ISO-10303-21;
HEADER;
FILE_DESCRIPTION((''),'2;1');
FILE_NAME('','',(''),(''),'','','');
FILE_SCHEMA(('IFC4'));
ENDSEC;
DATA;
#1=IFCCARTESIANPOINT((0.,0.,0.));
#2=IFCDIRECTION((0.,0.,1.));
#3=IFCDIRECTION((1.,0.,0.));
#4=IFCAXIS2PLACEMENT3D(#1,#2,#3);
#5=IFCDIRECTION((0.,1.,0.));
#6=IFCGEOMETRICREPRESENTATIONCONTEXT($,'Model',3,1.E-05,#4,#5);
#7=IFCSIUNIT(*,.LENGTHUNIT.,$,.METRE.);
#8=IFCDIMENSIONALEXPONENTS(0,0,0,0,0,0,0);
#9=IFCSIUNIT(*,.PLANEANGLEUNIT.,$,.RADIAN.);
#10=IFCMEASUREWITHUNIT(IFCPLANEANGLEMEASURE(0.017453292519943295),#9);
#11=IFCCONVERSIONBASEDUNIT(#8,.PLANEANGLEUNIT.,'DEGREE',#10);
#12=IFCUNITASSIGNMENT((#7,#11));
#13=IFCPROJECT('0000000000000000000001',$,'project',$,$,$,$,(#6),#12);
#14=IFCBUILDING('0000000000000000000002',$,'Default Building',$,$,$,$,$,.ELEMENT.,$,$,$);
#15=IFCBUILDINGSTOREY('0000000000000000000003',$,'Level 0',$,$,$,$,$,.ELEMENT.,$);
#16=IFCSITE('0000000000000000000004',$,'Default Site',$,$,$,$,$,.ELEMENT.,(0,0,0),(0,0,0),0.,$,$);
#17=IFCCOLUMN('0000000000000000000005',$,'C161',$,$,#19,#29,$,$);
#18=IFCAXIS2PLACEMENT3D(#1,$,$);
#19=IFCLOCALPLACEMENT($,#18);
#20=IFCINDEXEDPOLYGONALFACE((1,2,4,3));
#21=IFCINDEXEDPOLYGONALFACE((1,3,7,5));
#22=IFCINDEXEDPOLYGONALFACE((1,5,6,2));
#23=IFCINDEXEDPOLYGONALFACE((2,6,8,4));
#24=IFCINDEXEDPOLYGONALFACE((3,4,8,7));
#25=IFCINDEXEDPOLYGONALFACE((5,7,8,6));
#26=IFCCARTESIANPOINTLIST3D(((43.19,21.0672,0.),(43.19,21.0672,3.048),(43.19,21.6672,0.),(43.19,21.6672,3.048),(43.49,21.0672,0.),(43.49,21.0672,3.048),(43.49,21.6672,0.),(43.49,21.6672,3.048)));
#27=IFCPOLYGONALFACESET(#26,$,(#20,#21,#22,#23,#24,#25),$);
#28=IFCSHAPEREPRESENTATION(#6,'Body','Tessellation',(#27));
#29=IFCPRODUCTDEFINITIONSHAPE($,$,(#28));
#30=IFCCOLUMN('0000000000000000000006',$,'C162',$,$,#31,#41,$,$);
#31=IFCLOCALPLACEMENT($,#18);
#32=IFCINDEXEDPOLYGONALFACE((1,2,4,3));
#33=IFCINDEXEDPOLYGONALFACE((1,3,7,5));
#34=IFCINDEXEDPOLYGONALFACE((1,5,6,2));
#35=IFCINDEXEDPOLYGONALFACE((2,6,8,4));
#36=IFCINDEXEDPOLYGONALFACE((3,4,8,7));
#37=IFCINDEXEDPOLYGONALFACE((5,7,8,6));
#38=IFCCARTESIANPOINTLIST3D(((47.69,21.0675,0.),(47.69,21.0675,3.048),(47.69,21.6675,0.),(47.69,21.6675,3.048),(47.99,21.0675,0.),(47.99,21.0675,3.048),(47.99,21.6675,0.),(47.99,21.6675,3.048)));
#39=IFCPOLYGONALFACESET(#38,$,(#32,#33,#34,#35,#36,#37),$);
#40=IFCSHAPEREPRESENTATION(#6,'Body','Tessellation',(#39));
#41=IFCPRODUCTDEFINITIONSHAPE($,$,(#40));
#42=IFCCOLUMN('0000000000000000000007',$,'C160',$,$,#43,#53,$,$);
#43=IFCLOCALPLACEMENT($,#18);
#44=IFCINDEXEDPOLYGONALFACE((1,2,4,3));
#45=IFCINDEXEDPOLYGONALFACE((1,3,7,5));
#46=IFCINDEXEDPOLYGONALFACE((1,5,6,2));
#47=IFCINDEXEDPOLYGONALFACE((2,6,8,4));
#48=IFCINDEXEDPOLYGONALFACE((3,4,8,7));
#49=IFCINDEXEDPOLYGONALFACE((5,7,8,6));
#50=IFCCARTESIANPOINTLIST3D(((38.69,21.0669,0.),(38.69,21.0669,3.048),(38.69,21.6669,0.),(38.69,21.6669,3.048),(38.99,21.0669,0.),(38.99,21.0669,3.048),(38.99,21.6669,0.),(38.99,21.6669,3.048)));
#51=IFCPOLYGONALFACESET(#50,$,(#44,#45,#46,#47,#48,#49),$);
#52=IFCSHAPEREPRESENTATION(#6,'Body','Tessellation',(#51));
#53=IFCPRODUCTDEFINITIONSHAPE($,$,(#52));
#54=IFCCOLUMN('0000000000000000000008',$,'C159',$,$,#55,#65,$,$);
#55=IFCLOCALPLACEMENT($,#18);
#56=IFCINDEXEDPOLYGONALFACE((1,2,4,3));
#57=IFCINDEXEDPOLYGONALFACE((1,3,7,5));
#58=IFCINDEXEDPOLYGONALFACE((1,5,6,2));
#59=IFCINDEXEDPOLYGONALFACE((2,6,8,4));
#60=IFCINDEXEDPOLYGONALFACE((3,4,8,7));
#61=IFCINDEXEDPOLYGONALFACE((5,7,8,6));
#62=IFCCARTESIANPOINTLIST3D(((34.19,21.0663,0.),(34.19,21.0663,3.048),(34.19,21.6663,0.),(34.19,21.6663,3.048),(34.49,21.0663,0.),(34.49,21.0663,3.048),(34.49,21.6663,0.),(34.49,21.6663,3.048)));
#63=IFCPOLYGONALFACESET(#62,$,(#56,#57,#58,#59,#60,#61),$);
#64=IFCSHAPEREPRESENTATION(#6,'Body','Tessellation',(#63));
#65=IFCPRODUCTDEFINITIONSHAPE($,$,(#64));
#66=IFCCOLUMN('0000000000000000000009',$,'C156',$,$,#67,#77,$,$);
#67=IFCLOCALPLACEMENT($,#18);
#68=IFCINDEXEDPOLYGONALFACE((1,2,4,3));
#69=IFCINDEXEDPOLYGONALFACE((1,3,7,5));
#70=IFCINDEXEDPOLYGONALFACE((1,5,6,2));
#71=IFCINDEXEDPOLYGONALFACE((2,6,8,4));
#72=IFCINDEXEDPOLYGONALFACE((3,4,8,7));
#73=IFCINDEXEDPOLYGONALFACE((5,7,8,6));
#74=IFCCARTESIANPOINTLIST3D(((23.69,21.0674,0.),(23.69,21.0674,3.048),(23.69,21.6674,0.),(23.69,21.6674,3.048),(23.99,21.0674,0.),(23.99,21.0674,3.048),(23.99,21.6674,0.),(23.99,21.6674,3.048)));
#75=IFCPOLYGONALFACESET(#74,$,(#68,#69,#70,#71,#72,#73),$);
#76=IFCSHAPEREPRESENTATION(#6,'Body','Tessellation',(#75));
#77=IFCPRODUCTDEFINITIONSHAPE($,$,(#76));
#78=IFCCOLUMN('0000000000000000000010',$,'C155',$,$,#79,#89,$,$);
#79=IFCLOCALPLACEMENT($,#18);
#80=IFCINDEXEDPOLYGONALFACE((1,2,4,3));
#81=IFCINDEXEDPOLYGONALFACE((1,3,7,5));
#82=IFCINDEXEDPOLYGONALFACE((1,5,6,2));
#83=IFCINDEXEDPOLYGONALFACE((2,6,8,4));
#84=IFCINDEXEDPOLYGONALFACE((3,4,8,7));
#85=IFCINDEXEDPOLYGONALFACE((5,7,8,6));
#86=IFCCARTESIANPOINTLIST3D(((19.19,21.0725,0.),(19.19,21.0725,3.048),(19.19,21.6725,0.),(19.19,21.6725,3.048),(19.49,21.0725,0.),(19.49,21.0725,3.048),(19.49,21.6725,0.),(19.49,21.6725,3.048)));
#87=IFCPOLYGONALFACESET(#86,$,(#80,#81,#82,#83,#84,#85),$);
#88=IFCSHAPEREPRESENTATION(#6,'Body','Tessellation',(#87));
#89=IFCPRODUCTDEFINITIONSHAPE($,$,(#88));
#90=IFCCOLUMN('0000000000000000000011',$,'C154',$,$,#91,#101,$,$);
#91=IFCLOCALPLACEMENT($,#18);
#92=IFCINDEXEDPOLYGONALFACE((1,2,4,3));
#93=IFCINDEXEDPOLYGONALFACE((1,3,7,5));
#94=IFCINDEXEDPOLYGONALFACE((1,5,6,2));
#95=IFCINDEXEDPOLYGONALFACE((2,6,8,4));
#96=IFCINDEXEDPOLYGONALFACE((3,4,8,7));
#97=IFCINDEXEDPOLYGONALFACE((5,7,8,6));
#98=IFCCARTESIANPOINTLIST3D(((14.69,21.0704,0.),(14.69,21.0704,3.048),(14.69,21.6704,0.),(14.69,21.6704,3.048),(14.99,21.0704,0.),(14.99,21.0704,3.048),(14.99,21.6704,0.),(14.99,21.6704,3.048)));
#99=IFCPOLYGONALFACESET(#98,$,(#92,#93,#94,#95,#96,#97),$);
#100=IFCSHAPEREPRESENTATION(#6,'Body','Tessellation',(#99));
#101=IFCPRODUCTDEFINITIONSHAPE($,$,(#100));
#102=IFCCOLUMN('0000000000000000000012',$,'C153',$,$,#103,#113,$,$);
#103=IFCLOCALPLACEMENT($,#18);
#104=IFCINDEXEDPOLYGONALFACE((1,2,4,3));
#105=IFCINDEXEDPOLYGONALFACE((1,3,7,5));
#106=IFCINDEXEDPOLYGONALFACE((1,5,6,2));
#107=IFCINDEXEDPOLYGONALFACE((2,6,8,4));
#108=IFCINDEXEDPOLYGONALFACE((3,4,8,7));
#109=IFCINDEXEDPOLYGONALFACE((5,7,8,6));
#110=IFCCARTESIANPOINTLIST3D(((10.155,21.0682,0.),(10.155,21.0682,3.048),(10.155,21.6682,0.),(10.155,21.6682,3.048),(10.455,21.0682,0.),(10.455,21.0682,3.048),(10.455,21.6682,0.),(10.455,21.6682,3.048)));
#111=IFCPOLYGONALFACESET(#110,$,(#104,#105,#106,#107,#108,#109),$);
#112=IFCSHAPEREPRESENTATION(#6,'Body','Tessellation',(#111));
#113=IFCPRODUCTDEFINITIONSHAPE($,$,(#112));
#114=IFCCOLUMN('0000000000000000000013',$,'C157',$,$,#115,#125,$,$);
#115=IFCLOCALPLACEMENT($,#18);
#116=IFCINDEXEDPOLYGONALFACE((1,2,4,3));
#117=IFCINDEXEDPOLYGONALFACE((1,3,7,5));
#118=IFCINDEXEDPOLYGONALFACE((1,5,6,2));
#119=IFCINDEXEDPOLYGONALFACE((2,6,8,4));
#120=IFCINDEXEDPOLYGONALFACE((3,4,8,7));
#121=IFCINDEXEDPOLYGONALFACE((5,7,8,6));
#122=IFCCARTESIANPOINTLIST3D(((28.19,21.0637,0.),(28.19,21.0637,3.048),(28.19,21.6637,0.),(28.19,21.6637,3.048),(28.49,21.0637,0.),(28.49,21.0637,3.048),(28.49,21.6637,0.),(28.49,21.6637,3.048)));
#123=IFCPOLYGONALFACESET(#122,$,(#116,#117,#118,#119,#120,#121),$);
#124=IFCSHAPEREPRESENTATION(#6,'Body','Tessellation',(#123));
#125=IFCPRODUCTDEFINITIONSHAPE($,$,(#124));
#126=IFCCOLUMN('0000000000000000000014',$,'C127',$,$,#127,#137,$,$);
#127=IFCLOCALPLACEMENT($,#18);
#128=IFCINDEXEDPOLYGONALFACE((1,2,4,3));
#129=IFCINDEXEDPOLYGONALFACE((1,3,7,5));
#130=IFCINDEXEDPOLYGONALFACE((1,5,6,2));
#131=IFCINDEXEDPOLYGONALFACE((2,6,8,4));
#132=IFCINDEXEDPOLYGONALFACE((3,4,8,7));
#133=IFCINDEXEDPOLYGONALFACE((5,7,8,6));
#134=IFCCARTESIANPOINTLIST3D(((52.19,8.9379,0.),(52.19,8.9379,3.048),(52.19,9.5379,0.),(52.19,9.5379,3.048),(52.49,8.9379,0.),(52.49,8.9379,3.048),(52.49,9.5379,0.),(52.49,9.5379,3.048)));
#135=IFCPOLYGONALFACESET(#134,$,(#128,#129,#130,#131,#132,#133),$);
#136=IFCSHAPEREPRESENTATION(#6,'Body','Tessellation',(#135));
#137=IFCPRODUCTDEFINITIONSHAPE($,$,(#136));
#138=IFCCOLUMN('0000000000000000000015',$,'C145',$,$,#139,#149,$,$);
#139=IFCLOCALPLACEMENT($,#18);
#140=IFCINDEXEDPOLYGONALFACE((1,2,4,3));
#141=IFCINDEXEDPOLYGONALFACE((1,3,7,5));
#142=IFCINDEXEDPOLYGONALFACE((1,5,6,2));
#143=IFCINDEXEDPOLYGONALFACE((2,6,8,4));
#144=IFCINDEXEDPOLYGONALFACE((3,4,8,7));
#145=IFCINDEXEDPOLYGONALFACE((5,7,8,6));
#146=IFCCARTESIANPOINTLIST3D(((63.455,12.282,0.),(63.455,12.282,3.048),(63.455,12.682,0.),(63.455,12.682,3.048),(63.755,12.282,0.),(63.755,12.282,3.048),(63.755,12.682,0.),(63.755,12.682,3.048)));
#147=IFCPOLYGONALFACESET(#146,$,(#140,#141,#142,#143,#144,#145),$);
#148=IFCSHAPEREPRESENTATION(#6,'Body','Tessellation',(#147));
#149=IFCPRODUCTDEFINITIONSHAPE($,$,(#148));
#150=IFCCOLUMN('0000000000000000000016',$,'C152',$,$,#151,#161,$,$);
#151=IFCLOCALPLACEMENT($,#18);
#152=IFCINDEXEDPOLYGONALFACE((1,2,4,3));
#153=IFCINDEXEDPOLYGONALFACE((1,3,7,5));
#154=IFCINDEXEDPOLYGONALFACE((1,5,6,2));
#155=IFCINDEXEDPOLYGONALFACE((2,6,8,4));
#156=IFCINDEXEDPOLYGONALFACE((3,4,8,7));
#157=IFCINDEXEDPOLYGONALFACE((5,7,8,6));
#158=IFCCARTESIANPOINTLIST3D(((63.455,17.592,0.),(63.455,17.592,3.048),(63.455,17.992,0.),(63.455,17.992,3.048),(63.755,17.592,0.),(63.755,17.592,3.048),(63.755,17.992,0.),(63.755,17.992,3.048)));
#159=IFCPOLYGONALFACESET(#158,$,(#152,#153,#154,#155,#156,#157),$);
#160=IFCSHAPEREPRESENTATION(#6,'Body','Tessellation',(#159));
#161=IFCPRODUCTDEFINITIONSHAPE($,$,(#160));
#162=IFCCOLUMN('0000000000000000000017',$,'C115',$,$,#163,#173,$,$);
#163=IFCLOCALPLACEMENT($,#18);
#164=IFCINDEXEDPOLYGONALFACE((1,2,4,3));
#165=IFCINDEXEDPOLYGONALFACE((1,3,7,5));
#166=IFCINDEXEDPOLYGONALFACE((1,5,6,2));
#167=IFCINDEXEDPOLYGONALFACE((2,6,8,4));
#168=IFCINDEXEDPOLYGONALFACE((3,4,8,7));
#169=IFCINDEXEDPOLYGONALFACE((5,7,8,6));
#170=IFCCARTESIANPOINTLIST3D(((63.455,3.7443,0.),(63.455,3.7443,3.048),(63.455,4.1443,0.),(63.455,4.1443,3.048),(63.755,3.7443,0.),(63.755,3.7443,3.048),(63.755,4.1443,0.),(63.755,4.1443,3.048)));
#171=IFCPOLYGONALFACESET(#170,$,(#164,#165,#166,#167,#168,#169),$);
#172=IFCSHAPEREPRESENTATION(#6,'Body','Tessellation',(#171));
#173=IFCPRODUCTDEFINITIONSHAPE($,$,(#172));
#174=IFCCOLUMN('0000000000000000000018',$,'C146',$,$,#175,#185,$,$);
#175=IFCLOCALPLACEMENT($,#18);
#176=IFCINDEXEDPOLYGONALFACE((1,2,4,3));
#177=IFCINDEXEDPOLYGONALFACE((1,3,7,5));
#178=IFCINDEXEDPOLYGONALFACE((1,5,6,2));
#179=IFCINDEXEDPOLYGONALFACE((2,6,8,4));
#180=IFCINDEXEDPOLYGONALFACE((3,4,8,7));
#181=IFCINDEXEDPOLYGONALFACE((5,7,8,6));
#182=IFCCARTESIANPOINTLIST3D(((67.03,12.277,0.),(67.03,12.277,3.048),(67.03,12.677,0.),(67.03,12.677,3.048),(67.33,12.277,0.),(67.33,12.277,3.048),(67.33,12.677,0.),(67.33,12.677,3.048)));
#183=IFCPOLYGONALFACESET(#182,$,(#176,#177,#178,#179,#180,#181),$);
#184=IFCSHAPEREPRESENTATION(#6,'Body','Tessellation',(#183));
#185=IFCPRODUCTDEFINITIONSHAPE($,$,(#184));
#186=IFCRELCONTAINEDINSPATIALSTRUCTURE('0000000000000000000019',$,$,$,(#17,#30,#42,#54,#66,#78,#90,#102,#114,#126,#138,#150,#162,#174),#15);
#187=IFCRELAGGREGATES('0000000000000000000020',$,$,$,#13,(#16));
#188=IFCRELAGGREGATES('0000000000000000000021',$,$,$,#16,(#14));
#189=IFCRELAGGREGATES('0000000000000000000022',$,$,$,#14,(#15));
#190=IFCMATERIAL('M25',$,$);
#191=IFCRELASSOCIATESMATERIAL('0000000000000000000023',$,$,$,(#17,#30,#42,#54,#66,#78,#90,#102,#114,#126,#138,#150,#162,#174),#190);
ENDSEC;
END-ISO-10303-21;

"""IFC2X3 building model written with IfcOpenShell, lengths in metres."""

from ifc_helpers import new_model, entity, si_unit, converted_unit, direction, frame, frame_2d, origin_with_axes, place, context, project, spatial, rectangle, extrude, material, element, save


model = new_model("IFC2X3")

# Units and contexts
model_context = context("Model", 3, precision=1e-05, world=origin_with_axes(), true_north=direction((0.0, 1.0, 0.0)))
ifc_project = project(units=[si_unit("LENGTHUNIT", "METRE"), converted_unit("PLANEANGLEUNIT", "DEGREE", entity("IfcPlaneAngleMeasure", 0.017453292519943295), si_unit("PLANEANGLEUNIT", "RADIAN"), dimensions=[0, 0, 0, 0, 0, 0, 0])], contexts=[model_context])

# Site, building, storey
site = spatial("IfcSite", under=ifc_project, Name="Default Site", CompositionType="ELEMENT", RefLatitude=(0, 0, 0), RefLongitude=(0, 0, 0), RefElevation=0.0)
building = spatial("IfcBuilding", under=site, Name="Default Building", CompositionType="ELEMENT")
storey = spatial("IfcBuildingStorey", under=building, Name="Level 0", CompositionType="ELEMENT")

# Columns
ifc_material = material(Name="M25")
placement = place(None, origin_with_axes())
element("IfcColumn", 1, at=placement, inside=storey, material=ifc_material, Name="C161", context=model_context, shape_type="SweptSolid", body=[
    extrude(rectangle(XDim=0.3, YDim=0.6, at=frame_2d((0.0, 0.0), x_axis=(1.0, 0.0, 0.0))), frame((43.34, 21.3672, 0.0), z_axis=(0.0, 0.0, 1.0), x_axis=(1.0, 0.0, 0.0)), (0.0, 0.0, 1.0), 3.048),
])
element("IfcColumn", 2, at=placement, inside=storey, material=ifc_material, Name="C162", context=model_context, shape_type="SweptSolid", body=[
    extrude(rectangle(XDim=0.3, YDim=0.6, at=frame_2d((0.0, 0.0), x_axis=(1.0, 0.0, 0.0))), frame((47.84, 21.3675, 0.0), z_axis=(0.0, 0.0, 1.0), x_axis=(1.0, 0.0, 0.0)), (0.0, 0.0, 1.0), 3.048),
])
element("IfcColumn", 3, at=placement, inside=storey, material=ifc_material, Name="C160", context=model_context, shape_type="SweptSolid", body=[
    extrude(rectangle(XDim=0.3, YDim=0.6, at=frame_2d((0.0, 0.0), x_axis=(1.0, 0.0, 0.0))), frame((38.84, 21.3669, 0.0), z_axis=(0.0, 0.0, 1.0), x_axis=(1.0, 0.0, 0.0)), (0.0, 0.0, 1.0), 3.048),
])
element("IfcColumn", 4, at=placement, inside=storey, material=ifc_material, Name="C159", context=model_context, shape_type="SweptSolid", body=[
    extrude(rectangle(XDim=0.3, YDim=0.6, at=frame_2d((0.0, 0.0), x_axis=(1.0, 0.0, 0.0))), frame((34.34, 21.3663, 0.0), z_axis=(0.0, 0.0, 1.0), x_axis=(1.0, 0.0, 0.0)), (0.0, 0.0, 1.0), 3.048),
])
element("IfcColumn", 5, at=placement, inside=storey, material=ifc_material, Name="C156", context=model_context, shape_type="SweptSolid", body=[
    extrude(rectangle(XDim=0.3, YDim=0.6, at=frame_2d((0.0, 0.0), x_axis=(1.0, 0.0, 0.0))), frame((23.84, 21.3674, 0.0), z_axis=(0.0, 0.0, 1.0), x_axis=(1.0, 0.0, 0.0)), (0.0, 0.0, 1.0), 3.048),
])
element("IfcColumn", 6, at=placement, inside=storey, material=ifc_material, Name="C155", context=model_context, shape_type="SweptSolid", body=[
    extrude(rectangle(XDim=0.3, YDim=0.6, at=frame_2d((0.0, 0.0), x_axis=(1.0, 0.0, 0.0))), frame((19.34, 21.3725, 0.0), z_axis=(0.0, 0.0, 1.0), x_axis=(1.0, 0.0, 0.0)), (0.0, 0.0, 1.0), 3.048),
])
element("IfcColumn", 7, at=placement, inside=storey, material=ifc_material, Name="C154", context=model_context, shape_type="SweptSolid", body=[
    extrude(rectangle(XDim=0.3, YDim=0.6, at=frame_2d((0.0, 0.0), x_axis=(1.0, 0.0, 0.0))), frame((14.84, 21.3704, 0.0), z_axis=(0.0, 0.0, 1.0), x_axis=(1.0, 0.0, 0.0)), (0.0, 0.0, 1.0), 3.048),
])
element("IfcColumn", 8, at=placement, inside=storey, material=ifc_material, Name="C153", context=model_context, shape_type="SweptSolid", body=[
    extrude(rectangle(XDim=0.3, YDim=0.6, at=frame_2d((0.0, 0.0), x_axis=(1.0, 0.0, 0.0))), frame((10.305, 21.3682, 0.0), z_axis=(0.0, 0.0, 1.0), x_axis=(1.0, 0.0, 0.0)), (0.0, 0.0, 1.0), 3.048),
])
element("IfcColumn", 9, at=placement, inside=storey, material=ifc_material, Name="C157", context=model_context, shape_type="SweptSolid", body=[
    extrude(rectangle(XDim=0.3, YDim=0.6, at=frame_2d((0.0, 0.0), x_axis=(1.0, 0.0, 0.0))), frame((28.34, 21.3637, 0.0), z_axis=(0.0, 0.0, 1.0), x_axis=(1.0, 0.0, 0.0)), (0.0, 0.0, 1.0), 3.048),
])
element("IfcColumn", 10, at=placement, inside=storey, material=ifc_material, Name="C127", context=model_context, shape_type="SweptSolid", body=[
    extrude(rectangle(XDim=0.3, YDim=0.6, at=frame_2d((0.0, 0.0), x_axis=(1.0, 0.0, 0.0))), frame((52.34, 9.2379, 0.0), z_axis=(0.0, 0.0, 1.0), x_axis=(1.0, 0.0, 0.0)), (0.0, 0.0, 1.0), 3.048),
])
element("IfcColumn", 11, at=placement, inside=storey, material=ifc_material, Name="C145", context=model_context, shape_type="SweptSolid", body=[
    extrude(rectangle(XDim=0.3, YDim=0.4, at=frame_2d((0.0, 0.0), x_axis=(1.0, 0.0, 0.0))), frame((63.605, 12.482, 0.0), z_axis=(0.0, 0.0, 1.0), x_axis=(1.0, 0.0, 0.0)), (0.0, 0.0, 1.0), 3.048),
])
element("IfcColumn", 12, at=placement, inside=storey, material=ifc_material, Name="C152", context=model_context, shape_type="SweptSolid", body=[
    extrude(rectangle(XDim=0.3, YDim=0.4, at=frame_2d((0.0, 0.0), x_axis=(1.0, 0.0, 0.0))), frame((63.605, 17.792, 0.0), z_axis=(0.0, 0.0, 1.0), x_axis=(1.0, 0.0, 0.0)), (0.0, 0.0, 1.0), 3.048),
])
element("IfcColumn", 13, at=placement, inside=storey, material=ifc_material, Name="C115", context=model_context, shape_type="SweptSolid", body=[
    extrude(rectangle(XDim=0.3, YDim=0.4, at=frame_2d((0.0, 0.0), x_axis=(1.0, 0.0, 0.0))), frame((63.605, 3.9443, 0.0), z_axis=(0.0, 0.0, 1.0), x_axis=(1.0, 0.0, 0.0)), (0.0, 0.0, 1.0), 3.048),
])
element("IfcColumn", 14, at=placement, inside=storey, material=ifc_material, Name="C146", context=model_context, shape_type="SweptSolid", body=[
    extrude(rectangle(XDim=0.3, YDim=0.4, at=frame_2d((0.0, 0.0), x_axis=(1.0, 0.0, 0.0))), frame((67.18, 12.477, 0.0), z_axis=(0.0, 0.0, 1.0), x_axis=(1.0, 0.0, 0.0)), (0.0, 0.0, 1.0), 3.048),
])

save(model, "model.ifc")
